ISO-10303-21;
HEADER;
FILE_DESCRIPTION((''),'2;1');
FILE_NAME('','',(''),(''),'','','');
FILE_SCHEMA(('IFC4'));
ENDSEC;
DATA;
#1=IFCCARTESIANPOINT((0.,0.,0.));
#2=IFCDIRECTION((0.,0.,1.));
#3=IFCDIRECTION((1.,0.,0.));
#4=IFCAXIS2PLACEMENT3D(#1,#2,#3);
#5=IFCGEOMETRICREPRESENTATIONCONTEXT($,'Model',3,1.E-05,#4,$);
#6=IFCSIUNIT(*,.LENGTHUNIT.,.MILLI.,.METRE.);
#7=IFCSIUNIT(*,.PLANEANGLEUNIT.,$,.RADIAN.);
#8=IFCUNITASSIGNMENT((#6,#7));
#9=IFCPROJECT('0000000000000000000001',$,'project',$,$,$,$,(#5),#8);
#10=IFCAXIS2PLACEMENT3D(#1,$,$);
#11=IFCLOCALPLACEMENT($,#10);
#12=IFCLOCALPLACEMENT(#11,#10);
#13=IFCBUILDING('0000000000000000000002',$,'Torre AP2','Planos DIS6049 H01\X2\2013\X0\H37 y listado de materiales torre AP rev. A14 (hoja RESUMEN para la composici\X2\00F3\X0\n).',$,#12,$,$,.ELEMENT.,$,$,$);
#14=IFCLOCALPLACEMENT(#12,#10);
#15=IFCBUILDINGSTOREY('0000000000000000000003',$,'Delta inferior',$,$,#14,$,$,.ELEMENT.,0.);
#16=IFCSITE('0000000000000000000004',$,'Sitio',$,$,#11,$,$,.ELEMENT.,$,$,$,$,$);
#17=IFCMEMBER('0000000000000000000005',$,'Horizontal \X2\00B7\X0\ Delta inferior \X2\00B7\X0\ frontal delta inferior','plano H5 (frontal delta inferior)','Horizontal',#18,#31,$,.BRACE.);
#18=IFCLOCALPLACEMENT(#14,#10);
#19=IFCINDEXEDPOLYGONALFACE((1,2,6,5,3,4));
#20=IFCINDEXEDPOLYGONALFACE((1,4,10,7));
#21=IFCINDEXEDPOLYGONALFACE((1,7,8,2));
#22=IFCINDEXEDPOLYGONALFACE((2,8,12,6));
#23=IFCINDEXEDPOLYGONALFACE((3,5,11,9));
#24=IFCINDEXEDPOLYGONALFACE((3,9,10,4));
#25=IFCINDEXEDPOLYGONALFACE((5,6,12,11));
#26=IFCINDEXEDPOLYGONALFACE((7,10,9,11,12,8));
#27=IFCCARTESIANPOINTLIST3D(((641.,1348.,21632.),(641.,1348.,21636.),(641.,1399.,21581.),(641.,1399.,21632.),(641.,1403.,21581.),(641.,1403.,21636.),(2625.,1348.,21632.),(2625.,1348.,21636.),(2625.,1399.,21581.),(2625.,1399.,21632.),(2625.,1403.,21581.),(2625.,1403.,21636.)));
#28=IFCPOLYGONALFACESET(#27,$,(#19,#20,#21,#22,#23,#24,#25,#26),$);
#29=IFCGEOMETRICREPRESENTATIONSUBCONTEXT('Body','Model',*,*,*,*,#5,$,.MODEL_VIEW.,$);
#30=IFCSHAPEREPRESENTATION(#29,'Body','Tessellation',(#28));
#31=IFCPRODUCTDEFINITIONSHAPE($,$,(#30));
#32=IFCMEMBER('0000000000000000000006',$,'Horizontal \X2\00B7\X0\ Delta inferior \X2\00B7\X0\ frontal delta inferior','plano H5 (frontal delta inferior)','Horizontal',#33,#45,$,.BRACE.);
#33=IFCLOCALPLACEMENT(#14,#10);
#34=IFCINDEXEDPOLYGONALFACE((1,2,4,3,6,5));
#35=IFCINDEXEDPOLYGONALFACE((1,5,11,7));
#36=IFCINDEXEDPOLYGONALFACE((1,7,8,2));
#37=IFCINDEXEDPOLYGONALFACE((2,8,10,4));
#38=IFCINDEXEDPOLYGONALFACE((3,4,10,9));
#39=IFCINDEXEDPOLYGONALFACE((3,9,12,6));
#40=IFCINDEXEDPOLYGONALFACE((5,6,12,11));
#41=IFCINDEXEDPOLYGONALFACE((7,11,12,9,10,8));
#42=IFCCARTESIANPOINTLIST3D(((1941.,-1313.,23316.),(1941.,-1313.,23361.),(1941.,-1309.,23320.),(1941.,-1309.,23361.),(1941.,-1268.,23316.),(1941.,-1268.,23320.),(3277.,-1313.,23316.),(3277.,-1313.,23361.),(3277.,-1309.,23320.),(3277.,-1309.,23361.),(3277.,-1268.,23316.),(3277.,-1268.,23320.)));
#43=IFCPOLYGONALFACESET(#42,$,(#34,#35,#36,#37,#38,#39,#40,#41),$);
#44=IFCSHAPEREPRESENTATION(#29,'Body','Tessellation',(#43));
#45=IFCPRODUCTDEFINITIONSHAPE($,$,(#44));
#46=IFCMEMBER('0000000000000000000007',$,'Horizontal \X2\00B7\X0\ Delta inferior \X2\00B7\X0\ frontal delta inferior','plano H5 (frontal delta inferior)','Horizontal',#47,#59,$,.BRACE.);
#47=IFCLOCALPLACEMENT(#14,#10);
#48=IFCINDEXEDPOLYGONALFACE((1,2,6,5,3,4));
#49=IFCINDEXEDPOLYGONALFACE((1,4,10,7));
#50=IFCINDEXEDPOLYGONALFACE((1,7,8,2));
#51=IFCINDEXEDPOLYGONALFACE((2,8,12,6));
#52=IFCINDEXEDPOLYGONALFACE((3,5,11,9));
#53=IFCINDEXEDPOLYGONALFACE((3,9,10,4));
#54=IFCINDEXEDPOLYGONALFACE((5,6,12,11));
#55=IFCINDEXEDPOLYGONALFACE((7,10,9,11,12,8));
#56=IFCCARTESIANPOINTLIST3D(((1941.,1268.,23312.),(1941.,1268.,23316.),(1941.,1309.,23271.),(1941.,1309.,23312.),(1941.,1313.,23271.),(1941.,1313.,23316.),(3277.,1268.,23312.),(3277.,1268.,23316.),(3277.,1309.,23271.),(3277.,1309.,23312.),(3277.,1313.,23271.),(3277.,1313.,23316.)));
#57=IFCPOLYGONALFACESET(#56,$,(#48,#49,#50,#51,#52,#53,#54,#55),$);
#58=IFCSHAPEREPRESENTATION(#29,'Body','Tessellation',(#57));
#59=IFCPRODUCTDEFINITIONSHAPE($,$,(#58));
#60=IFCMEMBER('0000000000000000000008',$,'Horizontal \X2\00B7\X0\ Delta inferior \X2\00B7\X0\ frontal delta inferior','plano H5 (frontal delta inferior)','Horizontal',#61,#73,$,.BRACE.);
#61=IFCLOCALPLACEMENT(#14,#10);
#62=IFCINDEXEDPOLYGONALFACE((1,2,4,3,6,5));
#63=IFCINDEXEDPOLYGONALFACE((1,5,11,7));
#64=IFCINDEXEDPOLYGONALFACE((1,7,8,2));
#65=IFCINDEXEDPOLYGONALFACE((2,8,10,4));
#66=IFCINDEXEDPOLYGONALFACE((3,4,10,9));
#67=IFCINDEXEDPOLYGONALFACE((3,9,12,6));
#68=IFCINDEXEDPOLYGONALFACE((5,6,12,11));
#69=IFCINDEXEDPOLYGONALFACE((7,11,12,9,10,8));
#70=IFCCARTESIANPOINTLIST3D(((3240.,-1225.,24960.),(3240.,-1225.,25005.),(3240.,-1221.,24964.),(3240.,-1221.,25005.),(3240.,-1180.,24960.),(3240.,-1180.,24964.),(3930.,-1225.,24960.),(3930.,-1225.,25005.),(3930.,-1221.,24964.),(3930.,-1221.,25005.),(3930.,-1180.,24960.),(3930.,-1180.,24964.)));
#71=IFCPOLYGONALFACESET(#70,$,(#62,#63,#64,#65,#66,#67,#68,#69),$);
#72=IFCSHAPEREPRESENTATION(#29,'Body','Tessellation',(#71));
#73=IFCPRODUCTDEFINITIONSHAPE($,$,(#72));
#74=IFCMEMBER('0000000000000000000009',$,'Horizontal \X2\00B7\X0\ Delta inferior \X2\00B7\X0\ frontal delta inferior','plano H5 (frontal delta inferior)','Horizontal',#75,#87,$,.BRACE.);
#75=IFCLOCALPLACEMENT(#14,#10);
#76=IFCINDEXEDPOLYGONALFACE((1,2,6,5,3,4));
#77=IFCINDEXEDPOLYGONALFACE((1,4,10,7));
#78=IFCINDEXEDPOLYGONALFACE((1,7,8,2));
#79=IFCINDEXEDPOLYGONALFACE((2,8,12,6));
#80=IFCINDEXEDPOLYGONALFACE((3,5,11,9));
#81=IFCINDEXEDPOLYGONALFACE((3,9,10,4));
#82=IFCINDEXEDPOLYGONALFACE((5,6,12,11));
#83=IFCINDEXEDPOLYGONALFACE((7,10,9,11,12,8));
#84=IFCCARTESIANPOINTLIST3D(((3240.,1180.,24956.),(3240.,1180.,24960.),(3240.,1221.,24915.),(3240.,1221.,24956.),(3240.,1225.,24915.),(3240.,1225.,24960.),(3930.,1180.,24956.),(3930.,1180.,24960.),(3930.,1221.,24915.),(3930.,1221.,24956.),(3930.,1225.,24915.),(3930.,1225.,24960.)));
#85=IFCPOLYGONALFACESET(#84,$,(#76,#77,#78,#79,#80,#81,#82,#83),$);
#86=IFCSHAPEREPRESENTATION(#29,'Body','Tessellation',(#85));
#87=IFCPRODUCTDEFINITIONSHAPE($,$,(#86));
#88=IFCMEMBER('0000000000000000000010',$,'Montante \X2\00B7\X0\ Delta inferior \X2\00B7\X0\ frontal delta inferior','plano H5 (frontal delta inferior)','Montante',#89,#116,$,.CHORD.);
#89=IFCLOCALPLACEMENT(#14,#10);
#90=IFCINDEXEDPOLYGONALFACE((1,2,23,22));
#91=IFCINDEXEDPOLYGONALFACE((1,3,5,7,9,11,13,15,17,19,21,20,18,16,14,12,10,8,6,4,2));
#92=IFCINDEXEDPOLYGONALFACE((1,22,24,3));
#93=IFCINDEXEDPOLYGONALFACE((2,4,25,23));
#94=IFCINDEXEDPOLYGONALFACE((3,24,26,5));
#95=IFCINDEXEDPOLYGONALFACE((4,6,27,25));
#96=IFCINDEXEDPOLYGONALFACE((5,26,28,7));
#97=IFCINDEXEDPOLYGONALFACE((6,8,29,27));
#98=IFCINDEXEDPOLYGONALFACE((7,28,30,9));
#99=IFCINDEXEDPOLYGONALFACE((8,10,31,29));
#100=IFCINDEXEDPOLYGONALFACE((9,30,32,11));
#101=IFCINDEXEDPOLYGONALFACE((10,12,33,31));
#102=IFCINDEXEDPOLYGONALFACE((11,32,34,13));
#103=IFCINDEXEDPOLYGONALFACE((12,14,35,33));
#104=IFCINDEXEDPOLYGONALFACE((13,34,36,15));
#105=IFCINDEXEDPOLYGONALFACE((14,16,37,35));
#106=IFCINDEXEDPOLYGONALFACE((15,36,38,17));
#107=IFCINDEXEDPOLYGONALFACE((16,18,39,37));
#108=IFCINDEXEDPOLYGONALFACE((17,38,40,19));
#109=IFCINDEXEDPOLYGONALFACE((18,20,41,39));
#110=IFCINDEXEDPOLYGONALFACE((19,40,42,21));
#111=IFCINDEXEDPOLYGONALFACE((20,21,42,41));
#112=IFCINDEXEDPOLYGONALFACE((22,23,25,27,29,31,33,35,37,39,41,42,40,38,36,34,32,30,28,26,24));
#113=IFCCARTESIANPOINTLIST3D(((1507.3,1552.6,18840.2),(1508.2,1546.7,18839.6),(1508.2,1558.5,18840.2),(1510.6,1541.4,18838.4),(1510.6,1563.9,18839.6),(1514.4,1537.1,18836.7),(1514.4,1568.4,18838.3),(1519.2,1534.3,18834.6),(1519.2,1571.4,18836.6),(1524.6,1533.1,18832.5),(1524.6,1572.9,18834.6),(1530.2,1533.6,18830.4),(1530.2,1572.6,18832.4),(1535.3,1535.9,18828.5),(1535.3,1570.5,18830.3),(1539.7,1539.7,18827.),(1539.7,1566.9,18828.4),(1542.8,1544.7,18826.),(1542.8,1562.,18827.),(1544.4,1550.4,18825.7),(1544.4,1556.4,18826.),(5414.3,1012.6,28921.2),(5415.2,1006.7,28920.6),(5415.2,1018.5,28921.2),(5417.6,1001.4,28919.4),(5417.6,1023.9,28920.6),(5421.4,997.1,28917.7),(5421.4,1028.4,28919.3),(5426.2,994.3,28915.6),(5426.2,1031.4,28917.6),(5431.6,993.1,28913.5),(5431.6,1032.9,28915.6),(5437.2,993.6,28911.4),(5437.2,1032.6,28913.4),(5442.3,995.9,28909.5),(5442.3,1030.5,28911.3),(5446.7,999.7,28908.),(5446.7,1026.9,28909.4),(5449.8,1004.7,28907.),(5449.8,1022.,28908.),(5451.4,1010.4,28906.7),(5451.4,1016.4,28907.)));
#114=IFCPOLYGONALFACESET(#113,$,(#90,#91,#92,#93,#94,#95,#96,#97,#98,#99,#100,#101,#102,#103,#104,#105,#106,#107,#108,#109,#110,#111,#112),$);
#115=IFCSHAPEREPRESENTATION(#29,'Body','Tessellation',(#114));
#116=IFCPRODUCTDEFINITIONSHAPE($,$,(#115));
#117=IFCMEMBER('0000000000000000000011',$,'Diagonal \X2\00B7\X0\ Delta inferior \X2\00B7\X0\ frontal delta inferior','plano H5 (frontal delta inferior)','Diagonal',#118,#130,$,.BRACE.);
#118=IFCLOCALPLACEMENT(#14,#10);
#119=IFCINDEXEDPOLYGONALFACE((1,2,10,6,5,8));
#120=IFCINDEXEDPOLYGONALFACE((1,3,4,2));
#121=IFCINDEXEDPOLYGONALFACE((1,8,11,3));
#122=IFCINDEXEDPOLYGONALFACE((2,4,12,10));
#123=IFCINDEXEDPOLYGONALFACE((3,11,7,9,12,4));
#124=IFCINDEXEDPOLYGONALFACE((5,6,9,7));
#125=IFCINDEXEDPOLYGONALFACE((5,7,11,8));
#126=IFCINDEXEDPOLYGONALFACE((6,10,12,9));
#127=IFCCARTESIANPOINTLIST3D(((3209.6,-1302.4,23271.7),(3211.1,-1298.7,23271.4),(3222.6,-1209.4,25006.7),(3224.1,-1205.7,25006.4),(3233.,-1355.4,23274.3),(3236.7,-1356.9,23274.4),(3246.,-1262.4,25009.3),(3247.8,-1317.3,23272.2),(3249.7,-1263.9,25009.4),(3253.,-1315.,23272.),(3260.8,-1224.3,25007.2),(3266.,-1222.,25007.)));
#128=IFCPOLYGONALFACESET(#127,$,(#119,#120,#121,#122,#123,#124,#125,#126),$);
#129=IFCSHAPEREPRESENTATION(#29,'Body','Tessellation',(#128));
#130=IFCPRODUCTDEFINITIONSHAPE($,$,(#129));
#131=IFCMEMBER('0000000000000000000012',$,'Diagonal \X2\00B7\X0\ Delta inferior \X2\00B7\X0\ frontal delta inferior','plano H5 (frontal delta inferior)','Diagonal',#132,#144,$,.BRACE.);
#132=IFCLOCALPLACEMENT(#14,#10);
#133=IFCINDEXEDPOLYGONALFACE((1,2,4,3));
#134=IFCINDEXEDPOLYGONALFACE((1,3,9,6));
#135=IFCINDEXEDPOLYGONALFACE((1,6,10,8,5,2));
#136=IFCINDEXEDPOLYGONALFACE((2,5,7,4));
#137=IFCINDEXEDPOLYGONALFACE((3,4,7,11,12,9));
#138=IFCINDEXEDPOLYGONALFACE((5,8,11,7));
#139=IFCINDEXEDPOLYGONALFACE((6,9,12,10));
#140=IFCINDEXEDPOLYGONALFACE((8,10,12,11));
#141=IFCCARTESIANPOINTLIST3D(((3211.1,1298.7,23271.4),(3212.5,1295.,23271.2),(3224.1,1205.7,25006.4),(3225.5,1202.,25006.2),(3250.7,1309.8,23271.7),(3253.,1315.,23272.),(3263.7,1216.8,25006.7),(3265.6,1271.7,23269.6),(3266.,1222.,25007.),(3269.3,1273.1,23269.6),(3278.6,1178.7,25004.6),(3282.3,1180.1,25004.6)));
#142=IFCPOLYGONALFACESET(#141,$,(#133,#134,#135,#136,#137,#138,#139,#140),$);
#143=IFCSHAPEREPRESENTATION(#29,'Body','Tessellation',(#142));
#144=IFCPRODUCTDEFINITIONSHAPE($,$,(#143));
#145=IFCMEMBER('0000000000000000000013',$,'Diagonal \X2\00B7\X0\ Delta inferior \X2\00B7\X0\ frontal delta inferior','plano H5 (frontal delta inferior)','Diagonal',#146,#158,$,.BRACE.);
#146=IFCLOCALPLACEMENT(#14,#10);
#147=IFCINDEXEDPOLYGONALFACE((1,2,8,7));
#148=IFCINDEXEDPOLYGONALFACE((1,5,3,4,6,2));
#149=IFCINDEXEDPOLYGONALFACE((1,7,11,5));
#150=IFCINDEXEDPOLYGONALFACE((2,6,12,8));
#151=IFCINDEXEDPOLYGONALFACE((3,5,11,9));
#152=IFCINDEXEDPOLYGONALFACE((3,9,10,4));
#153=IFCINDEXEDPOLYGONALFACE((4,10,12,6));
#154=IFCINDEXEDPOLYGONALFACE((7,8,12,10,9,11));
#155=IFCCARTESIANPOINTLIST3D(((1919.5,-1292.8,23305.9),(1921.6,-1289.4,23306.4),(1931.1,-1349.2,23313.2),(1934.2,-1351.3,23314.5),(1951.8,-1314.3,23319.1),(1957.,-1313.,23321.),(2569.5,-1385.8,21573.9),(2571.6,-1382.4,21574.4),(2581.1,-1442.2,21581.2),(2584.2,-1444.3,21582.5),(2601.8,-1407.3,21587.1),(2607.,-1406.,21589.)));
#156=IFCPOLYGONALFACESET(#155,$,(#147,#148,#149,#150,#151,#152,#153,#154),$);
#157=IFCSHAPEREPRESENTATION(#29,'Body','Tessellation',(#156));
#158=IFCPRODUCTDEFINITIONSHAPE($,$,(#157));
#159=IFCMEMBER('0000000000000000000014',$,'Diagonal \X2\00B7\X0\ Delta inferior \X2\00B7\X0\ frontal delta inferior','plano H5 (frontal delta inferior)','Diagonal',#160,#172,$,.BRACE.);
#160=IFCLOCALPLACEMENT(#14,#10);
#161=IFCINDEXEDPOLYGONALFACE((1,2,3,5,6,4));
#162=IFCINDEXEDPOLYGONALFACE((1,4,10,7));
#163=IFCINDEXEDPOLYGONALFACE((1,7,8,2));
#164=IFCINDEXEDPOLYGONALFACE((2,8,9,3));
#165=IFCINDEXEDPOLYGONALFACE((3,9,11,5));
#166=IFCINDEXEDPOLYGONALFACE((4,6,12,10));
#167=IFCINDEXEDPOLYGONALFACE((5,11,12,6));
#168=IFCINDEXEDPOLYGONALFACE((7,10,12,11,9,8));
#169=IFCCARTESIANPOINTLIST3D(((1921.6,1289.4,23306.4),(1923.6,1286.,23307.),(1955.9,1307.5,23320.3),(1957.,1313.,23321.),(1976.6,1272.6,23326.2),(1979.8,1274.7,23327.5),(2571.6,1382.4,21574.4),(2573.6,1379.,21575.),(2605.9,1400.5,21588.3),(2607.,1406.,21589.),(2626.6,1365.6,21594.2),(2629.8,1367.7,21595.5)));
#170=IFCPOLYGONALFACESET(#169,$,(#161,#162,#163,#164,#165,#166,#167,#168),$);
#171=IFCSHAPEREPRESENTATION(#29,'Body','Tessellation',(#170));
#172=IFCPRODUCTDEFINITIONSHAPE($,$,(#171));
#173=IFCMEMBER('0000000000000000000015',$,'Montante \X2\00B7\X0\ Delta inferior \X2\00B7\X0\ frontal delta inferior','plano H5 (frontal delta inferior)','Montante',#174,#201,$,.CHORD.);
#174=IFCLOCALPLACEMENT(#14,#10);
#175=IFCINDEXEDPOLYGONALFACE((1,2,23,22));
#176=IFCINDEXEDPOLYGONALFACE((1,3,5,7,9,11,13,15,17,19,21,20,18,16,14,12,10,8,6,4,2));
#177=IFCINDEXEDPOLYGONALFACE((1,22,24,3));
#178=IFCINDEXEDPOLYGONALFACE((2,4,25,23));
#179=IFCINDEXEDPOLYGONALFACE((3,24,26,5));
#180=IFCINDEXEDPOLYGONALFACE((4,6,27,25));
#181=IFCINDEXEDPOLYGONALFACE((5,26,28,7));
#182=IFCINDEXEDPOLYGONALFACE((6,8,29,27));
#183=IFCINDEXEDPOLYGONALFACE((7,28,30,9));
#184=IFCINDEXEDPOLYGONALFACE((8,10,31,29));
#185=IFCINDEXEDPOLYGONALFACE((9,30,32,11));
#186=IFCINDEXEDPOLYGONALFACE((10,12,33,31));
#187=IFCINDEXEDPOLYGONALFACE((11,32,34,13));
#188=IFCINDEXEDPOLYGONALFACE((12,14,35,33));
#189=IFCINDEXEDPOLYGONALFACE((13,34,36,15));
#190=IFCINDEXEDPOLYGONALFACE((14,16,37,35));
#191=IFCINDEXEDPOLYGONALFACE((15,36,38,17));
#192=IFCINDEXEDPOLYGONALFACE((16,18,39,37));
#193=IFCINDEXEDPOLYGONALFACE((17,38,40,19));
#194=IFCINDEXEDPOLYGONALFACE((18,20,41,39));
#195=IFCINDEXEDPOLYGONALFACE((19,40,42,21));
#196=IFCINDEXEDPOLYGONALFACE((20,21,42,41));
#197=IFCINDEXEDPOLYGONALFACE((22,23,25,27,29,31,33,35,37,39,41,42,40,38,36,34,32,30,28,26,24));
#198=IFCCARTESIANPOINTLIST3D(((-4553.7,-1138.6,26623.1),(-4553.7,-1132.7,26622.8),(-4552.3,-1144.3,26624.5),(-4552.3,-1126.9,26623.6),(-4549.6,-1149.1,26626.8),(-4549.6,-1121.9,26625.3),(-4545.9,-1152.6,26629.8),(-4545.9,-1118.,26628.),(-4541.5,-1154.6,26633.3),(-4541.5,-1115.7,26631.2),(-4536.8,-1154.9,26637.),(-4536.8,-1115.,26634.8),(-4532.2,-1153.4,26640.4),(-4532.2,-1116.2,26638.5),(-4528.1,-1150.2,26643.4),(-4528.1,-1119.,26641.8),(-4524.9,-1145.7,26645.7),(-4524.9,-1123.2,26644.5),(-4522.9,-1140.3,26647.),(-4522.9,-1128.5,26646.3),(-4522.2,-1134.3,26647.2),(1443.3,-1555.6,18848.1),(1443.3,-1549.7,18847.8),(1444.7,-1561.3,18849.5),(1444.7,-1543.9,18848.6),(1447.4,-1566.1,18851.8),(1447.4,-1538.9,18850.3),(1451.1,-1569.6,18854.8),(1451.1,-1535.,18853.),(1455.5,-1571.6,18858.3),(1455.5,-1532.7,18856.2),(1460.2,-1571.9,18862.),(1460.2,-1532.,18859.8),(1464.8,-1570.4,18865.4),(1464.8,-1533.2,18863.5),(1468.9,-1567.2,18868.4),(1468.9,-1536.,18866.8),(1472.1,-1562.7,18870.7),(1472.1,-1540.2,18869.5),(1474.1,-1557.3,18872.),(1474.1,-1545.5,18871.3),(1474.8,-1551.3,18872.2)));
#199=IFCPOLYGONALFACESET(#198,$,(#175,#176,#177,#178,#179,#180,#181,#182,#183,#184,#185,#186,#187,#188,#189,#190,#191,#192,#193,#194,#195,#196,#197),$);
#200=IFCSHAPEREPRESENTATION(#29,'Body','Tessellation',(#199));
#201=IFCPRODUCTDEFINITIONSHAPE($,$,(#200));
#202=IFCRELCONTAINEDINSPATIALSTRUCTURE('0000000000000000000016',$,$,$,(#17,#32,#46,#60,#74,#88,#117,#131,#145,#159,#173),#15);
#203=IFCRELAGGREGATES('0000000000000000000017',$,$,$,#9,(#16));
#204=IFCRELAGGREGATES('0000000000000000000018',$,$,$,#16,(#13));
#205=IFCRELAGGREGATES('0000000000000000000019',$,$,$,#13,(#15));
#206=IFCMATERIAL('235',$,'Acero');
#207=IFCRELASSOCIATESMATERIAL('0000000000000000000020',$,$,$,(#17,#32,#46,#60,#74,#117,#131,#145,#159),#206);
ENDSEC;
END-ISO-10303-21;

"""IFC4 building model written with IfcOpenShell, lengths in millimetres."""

from ifc_helpers import new_model, si_unit, frame, frame_2d, origin, origin_with_axes, place, context, subcontext, project, spatial, circle, l_section, extrude, material, element, save


model = new_model("IFC4")

# Units and contexts
model_context = context("Model", 3, precision=1e-05, world=origin_with_axes())
body_context = subcontext(model_context, "Body", "Model", "MODEL_VIEW")
ifc_project = project(units=[si_unit("LENGTHUNIT", "METRE", prefix="MILLI"), si_unit("PLANEANGLEUNIT", "RADIAN")], contexts=[model_context])

# Site, building, storey
site_placement = place(None, origin())
site = spatial("IfcSite", under=ifc_project, at=site_placement, Name="Sitio", CompositionType="ELEMENT")
building_placement = place(site_placement, origin())
building = spatial("IfcBuilding", under=site, at=building_placement, Name="Torre AP2", Description="Planos DIS6049 H01–H37 y listado de materiales torre AP rev. A14 (hoja RESUMEN para la composición).", CompositionType="ELEMENT")
storey_placement = place(building_placement, origin())
storey = spatial("IfcBuildingStorey", under=building, at=storey_placement, Name="Delta inferior", CompositionType="ELEMENT", Elevation=0.0)

# Members
ifc_material_1 = material(Name="235", Category="Acero")
member_1_placement = place(storey_placement, frame((641.0, 1403.0, 21636.0), z_axis=(1.0, 0.0, 0.0), x_axis=(0.0, -1.0, 0.0)))
element("IfcMember", 1, at=member_1_placement, inside=storey, material=ifc_material_1, Name="Horizontal · Delta inferior · frontal delta inferior", Description="plano H5 (frontal delta inferior)", ObjectType="Horizontal", PredefinedType="BRACE", context=body_context, shape_type="SweptSolid", body=[
    extrude(l_section(Depth=55.0, Width=55.0, Thickness=4.0, at=frame_2d((27.5, 27.5))), None, (0.0, 0.0, 1.0), 1984.0),
])
for number, where, z_axis, x_axis, name in (
    (2, (1941.0, -1313.0, 23316.0), (1.0, 0.0, 0.0), (0.0, 1.0, 0.0), "Horizontal · Delta inferior · frontal delta inferior"),
    (3, (1941.0, 1313.0, 23316.0), (1.0, 0.0, 0.0), (0.0, -1.0, 0.0), "Horizontal · Delta inferior · frontal delta inferior"),
):
    element("IfcMember", number, at=place(storey_placement, frame(where, z_axis=z_axis, x_axis=x_axis)), inside=storey, material=ifc_material_1, Name=name, Description="plano H5 (frontal delta inferior)", ObjectType="Horizontal", PredefinedType="BRACE", context=body_context, shape_type="SweptSolid", body=[
        extrude(l_section(Depth=45.0, Width=45.0, Thickness=4.0, at=frame_2d((22.5, 22.5))), None, (0.0, 0.0, 1.0), 1336.0),
    ])
for number, where, z_axis, x_axis, name in (
    (4, (3240.0, -1225.0, 24960.0), (1.0, 0.0, 0.0), (0.0, 1.0, 0.0), "Horizontal · Delta inferior · frontal delta inferior"),
    (5, (3240.0, 1225.0, 24960.0), (1.0, 0.0, 0.0), (0.0, -1.0, 0.0), "Horizontal · Delta inferior · frontal delta inferior"),
):
    element("IfcMember", number, at=place(storey_placement, frame(where, z_axis=z_axis, x_axis=x_axis)), inside=storey, material=ifc_material_1, Name=name, Description="plano H5 (frontal delta inferior)", ObjectType="Horizontal", PredefinedType="BRACE", context=body_context, shape_type="SweptSolid", body=[
        extrude(l_section(Depth=45.0, Width=45.0, Thickness=4.0, at=frame_2d((22.5, 22.5))), None, (0.0, 0.0, 1.0), 690.0),
    ])
for number, where, z_axis, x_axis, name in (
    (6, (1526.0, 1553.0, 18833.0), (0.36092, -0.049884, 0.931262), (-0.932597, -0.019305, 0.360404), "Montante · Delta inferior · frontal delta inferior"),
):
    element("IfcMember", number, at=place(storey_placement, frame(where, z_axis=z_axis, x_axis=x_axis)), inside=storey, Name=name, Description="plano H5 (frontal delta inferior)", ObjectType="Montante", PredefinedType="CHORD", context=body_context, shape_type="SweptSolid", body=[
        extrude(circle(Radius=20.0), None, (0.0, 0.0, 1.0), 10825.1),
    ])
for number, where, z_axis, x_axis, name in (
    (7, (3253.0, -1315.0, 23272.0), (0.007482, 0.053524, 0.998539), (-0.932081, 0.362036, -0.012422), "Diagonal · Delta inferior · frontal delta inferior"),
    (8, (3253.0, 1315.0, 23272.0), (0.007482, -0.053524, 0.998539), (-0.932081, -0.362036, -0.012422), "Diagonal · Delta inferior · frontal delta inferior"),
):
    element("IfcMember", number, at=place(storey_placement, frame(where, z_axis=z_axis, x_axis=x_axis)), inside=storey, material=ifc_material_1, Name=name, Description="plano H5 (frontal delta inferior)", ObjectType="Diagonal", PredefinedType="BRACE", context=body_context, shape_type="SweptSolid", body=[
        extrude(l_section(Depth=45.0, Width=45.0, Thickness=4.0, at=frame_2d((22.5, 22.5))), None, (0.0, 0.0, 1.0), 1737.5),
    ])
for number, where, z_axis, x_axis, name in (
    (9, (2607.0, -1406.0, 21589.0), (-0.350917, 0.050208, 0.935059), (-0.787637, 0.524232, -0.32374), "Diagonal · Delta inferior · frontal delta inferior"),
    (10, (2607.0, 1406.0, 21589.0), (-0.350917, -0.050208, 0.935059), (-0.787637, -0.524232, -0.32374), "Diagonal · Delta inferior · frontal delta inferior"),
):
    element("IfcMember", number, at=place(storey_placement, frame(where, z_axis=z_axis, x_axis=x_axis)), inside=storey, material=ifc_material_1, Name=name, Description="plano H5 (frontal delta inferior)", ObjectType="Diagonal", PredefinedType="BRACE", context=body_context, shape_type="SweptSolid", body=[
        extrude(l_section(Depth=45.0, Width=45.0, Thickness=4.0, at=frame_2d((22.5, 22.5))), None, (0.0, 0.0, 1.0), 1852.3),
    ])
for number, where, z_axis, x_axis, name in (
    (11, (1459.0, -1552.0, 18860.0), (-0.610199, 0.04243, 0.791111), (0.792248, 0.03268, 0.609323), "Montante · Delta inferior · frontal delta inferior"),
):
    element("IfcMember", number, at=place(storey_placement, frame(where, z_axis=z_axis, x_axis=x_axis)), inside=storey, Name=name, Description="plano H5 (frontal delta inferior)", ObjectType="Montante", PredefinedType="CHORD", context=body_context, shape_type="SweptSolid", body=[
        extrude(circle(Radius=20.0), None, (0.0, 0.0, 1.0), 9827.9),
    ])

save(model, "model.ifc")
